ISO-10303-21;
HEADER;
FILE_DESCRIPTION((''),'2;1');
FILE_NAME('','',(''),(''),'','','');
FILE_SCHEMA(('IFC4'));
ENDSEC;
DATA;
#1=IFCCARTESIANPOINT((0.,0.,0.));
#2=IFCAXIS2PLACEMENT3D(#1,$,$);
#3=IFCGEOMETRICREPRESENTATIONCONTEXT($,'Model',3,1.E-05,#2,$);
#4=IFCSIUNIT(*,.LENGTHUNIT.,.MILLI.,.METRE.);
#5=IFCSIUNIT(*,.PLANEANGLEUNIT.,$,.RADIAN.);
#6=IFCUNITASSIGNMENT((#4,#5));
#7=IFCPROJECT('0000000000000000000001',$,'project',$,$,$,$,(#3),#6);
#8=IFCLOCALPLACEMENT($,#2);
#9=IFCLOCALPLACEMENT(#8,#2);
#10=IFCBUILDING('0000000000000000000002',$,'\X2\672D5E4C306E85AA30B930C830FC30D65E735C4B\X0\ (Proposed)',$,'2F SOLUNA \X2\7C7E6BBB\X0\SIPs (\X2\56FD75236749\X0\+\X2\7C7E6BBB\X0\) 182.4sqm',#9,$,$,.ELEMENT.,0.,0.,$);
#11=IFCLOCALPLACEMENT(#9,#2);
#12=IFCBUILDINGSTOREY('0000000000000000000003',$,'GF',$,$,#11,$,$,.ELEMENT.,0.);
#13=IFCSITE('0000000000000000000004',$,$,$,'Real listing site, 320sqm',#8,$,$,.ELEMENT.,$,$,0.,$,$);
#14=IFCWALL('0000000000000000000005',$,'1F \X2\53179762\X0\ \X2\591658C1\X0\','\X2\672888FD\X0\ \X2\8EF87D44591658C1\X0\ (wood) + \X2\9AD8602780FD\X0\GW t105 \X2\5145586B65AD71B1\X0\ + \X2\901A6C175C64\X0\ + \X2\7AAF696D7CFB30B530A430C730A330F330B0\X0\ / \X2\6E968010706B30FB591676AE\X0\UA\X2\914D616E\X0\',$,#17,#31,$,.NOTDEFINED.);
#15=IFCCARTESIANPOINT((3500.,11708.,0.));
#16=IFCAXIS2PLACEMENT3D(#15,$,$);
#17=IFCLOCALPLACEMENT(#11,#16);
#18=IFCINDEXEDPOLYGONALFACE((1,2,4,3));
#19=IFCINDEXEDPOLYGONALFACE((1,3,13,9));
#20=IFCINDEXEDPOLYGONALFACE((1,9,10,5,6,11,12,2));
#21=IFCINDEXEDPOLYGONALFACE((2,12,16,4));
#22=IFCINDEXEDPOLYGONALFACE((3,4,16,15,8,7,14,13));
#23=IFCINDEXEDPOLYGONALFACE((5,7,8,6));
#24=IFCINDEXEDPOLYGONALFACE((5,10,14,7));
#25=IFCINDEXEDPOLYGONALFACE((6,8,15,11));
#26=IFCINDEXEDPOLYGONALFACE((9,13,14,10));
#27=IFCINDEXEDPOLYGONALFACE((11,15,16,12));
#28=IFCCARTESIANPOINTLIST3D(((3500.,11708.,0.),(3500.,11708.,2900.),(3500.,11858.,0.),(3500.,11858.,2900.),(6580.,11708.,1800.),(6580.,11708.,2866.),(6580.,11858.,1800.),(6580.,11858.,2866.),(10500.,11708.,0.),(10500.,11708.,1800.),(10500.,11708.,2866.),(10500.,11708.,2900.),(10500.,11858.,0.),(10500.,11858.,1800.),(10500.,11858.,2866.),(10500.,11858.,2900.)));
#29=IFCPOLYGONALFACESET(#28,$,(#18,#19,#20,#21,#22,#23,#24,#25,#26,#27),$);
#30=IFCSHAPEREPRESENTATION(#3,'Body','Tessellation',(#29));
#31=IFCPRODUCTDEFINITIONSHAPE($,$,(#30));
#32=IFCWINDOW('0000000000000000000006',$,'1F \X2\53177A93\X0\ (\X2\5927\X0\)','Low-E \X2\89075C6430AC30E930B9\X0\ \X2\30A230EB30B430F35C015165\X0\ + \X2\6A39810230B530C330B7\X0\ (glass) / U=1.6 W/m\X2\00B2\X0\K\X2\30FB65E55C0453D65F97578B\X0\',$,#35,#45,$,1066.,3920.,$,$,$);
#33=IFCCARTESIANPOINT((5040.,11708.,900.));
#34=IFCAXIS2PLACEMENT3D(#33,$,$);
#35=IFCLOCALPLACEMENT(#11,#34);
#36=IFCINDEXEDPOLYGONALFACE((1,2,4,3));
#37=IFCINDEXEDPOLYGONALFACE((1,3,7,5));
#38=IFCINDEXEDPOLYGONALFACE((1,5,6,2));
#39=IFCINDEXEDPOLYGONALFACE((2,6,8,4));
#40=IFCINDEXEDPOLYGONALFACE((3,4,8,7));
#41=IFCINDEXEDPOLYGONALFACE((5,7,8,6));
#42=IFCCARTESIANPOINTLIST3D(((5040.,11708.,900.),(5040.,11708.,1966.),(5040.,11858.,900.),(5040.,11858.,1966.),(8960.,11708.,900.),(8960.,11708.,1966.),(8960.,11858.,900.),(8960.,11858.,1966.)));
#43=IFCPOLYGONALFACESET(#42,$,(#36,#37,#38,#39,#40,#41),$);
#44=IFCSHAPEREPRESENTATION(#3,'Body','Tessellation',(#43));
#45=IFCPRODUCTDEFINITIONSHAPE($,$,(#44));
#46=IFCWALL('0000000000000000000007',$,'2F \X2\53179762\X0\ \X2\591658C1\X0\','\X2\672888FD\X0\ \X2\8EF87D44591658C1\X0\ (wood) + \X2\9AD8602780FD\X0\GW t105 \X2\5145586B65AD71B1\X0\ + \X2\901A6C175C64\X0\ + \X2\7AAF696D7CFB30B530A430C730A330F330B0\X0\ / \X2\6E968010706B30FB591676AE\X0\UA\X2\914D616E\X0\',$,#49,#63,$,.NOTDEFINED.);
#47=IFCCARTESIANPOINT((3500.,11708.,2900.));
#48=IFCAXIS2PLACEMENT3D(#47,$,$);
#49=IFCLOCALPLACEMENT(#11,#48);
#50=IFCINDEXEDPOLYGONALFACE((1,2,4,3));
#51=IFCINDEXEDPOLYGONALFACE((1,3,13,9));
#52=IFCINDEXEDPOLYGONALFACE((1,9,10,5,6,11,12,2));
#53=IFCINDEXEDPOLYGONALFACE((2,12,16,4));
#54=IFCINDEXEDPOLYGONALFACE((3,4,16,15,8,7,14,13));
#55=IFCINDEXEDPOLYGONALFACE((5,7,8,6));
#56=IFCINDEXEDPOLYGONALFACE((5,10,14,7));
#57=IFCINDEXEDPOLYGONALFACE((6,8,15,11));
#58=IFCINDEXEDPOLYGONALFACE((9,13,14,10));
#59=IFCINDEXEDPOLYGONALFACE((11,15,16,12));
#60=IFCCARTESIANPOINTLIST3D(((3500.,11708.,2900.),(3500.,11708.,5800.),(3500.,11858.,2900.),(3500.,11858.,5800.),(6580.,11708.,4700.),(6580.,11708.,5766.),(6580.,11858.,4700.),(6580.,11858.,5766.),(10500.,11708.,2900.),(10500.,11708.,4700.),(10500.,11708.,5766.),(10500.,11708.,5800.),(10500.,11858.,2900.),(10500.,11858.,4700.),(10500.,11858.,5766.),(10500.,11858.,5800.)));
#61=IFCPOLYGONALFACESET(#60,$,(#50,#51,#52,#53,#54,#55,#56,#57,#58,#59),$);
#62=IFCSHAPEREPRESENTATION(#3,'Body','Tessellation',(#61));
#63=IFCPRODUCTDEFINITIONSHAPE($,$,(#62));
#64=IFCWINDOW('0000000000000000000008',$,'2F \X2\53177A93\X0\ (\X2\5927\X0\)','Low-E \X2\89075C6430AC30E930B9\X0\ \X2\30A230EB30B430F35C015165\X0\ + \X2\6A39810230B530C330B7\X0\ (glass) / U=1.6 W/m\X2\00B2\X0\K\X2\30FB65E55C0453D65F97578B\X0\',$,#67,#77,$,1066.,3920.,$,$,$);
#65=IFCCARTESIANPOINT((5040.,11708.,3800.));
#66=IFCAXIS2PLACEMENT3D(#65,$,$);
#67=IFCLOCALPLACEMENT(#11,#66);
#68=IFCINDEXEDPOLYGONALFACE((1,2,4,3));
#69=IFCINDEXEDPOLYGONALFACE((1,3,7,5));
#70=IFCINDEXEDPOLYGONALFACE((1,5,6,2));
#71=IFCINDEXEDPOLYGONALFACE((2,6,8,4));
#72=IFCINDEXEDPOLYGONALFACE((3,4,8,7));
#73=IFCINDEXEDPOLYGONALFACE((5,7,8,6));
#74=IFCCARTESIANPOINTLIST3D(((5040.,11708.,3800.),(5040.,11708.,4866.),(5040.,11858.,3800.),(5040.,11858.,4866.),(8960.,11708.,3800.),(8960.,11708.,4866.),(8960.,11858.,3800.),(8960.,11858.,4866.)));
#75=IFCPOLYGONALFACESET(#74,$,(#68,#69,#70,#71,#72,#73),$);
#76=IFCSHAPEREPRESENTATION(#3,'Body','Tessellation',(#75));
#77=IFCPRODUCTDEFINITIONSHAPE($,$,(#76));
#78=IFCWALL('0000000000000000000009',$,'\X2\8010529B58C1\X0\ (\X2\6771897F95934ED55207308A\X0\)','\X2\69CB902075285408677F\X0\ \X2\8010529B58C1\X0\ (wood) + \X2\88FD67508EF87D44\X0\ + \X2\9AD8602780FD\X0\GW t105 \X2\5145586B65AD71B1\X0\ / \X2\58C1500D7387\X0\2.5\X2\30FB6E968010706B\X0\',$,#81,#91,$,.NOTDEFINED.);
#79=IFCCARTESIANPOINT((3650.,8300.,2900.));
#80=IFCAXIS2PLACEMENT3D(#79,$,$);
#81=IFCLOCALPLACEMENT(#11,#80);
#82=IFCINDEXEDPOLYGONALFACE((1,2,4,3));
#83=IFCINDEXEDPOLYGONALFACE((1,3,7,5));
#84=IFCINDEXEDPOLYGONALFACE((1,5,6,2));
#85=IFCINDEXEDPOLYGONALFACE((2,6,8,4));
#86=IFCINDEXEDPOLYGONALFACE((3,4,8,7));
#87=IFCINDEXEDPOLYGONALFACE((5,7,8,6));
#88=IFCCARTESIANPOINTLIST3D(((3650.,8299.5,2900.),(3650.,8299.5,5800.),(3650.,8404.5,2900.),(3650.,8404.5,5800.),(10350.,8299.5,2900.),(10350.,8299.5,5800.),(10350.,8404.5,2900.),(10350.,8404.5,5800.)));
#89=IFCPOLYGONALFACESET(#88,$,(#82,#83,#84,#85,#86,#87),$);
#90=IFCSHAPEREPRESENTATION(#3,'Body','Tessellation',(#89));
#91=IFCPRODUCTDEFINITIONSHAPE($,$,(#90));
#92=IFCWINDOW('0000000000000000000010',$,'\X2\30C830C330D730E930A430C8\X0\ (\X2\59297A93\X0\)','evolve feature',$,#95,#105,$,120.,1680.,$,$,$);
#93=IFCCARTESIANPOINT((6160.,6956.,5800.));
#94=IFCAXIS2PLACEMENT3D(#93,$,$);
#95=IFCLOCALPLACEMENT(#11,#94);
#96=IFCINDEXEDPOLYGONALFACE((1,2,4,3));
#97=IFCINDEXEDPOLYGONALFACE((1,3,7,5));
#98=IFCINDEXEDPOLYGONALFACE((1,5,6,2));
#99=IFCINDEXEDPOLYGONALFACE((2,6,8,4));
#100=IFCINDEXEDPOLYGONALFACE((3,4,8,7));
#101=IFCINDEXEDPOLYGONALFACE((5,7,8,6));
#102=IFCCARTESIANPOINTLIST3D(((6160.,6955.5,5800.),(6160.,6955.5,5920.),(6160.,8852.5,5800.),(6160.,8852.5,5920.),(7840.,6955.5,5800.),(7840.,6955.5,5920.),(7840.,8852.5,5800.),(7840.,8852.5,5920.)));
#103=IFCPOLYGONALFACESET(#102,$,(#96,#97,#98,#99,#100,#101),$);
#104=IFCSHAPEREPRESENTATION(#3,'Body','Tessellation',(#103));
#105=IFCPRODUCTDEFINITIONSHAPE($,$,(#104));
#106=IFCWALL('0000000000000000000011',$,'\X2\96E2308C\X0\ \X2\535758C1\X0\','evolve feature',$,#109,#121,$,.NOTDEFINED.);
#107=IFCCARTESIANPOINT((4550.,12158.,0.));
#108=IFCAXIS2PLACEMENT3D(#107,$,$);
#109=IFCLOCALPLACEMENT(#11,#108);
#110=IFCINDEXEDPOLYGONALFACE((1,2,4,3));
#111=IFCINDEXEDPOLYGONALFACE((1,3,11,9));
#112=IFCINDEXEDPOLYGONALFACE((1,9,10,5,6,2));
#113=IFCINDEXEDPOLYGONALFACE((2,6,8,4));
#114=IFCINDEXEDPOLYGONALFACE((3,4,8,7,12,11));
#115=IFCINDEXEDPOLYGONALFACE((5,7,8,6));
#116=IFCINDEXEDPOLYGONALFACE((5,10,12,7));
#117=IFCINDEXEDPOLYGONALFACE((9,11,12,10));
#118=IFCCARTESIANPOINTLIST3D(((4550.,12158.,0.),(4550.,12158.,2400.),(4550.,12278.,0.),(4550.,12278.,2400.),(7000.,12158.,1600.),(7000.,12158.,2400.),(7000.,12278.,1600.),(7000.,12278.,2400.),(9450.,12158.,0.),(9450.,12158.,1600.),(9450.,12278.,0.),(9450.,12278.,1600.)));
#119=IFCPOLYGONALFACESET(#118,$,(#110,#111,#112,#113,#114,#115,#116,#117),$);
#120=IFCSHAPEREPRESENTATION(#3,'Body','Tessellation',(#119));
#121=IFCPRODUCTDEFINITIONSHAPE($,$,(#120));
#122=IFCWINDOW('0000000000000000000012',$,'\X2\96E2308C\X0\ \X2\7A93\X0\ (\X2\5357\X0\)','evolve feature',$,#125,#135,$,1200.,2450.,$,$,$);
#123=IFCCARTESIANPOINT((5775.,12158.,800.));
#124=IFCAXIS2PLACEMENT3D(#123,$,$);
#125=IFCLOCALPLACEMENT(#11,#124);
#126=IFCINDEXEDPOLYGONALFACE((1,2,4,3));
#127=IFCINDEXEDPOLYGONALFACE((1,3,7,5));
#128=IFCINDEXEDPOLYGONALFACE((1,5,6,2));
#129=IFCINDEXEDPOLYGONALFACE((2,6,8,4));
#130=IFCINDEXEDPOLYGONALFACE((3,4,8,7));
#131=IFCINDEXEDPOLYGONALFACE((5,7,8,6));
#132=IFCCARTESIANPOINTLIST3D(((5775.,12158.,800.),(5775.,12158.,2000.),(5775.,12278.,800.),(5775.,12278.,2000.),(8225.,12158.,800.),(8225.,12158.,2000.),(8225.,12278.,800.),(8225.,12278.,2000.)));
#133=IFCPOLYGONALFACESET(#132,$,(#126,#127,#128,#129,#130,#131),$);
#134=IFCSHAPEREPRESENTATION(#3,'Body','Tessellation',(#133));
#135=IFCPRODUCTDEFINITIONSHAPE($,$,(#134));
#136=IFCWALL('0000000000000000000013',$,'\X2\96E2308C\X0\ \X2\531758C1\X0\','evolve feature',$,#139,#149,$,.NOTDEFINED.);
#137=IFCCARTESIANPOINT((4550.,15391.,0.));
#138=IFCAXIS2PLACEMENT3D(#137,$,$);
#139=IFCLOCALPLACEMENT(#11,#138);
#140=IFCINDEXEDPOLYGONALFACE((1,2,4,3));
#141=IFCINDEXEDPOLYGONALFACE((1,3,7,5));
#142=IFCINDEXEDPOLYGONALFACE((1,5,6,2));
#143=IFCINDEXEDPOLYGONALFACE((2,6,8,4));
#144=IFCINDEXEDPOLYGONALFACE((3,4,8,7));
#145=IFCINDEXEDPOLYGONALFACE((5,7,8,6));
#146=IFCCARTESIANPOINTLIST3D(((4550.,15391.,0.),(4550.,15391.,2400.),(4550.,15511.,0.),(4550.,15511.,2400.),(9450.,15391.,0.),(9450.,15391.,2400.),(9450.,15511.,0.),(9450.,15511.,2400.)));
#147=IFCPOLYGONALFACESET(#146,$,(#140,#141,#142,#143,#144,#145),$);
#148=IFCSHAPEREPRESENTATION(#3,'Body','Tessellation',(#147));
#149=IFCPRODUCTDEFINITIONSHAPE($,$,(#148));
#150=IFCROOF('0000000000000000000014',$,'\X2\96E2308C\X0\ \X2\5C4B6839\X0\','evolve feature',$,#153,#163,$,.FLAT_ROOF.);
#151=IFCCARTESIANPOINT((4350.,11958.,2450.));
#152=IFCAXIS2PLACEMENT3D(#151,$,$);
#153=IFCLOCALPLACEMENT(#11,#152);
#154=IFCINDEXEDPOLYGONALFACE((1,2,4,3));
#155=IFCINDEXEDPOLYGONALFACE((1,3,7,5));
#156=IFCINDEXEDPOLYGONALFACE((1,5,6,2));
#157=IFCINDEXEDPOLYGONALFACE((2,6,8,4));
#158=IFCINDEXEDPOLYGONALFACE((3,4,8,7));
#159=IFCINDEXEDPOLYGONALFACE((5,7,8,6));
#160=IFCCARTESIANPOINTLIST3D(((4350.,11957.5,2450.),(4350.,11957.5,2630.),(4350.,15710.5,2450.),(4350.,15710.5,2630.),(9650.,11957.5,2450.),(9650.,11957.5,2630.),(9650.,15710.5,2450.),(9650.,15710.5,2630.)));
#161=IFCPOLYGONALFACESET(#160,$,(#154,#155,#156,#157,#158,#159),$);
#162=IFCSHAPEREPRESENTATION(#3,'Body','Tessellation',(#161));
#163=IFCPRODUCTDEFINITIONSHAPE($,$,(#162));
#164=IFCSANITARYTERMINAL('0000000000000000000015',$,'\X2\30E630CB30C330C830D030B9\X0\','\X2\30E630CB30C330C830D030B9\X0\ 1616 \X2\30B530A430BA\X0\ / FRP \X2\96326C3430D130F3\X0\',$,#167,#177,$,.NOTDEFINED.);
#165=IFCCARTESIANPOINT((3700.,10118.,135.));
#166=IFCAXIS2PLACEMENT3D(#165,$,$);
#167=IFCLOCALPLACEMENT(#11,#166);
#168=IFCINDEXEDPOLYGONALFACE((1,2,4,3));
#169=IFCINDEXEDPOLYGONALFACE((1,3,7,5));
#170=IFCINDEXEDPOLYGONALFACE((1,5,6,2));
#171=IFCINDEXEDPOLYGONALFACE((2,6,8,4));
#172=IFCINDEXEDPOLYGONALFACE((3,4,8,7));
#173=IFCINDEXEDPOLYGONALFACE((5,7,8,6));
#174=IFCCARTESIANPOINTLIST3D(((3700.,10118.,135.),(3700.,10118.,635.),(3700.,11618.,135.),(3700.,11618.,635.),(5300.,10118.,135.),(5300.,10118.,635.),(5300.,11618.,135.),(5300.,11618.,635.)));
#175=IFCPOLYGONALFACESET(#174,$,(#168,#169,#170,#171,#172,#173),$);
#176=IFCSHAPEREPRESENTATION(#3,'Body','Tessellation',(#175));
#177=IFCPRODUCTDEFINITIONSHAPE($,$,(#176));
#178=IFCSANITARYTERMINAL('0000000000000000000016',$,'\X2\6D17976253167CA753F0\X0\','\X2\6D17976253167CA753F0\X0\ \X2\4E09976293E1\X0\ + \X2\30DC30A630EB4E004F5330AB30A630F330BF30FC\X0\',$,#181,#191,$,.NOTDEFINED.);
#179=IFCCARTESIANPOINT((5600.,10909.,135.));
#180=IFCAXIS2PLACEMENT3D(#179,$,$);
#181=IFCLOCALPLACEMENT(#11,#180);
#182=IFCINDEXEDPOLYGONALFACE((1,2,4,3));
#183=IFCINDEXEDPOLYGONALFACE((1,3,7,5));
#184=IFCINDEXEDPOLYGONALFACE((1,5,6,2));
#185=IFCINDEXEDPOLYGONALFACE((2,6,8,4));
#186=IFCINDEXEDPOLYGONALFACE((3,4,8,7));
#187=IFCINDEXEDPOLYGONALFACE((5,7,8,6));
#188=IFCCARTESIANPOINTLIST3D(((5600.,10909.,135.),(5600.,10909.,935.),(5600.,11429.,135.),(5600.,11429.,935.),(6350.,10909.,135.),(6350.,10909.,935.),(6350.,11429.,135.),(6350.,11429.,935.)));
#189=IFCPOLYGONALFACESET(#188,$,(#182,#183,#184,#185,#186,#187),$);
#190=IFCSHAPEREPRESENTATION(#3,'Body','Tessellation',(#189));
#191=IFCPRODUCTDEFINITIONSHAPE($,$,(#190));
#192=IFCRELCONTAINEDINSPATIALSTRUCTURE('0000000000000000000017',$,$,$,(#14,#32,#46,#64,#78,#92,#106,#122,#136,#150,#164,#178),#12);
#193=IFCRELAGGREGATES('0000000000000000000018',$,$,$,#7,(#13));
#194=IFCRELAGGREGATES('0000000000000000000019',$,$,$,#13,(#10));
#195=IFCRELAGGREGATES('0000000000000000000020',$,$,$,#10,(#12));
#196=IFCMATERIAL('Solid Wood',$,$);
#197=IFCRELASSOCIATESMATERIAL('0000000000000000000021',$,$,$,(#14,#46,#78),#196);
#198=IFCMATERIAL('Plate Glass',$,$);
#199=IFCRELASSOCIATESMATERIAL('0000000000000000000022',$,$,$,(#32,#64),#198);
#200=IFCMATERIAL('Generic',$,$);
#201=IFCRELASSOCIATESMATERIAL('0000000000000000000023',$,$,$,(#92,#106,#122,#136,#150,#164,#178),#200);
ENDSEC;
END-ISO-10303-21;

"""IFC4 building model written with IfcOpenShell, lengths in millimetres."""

from ifc_helpers import new_model, si_unit, frame, frame_2d, origin, place, context, project, spatial, rectangle, extrude, material, element, fill, save


model = new_model("IFC4")

# Units and contexts
model_context = context("Model", 3, precision=1e-05, world=origin())
ifc_project = project(units=[si_unit("LENGTHUNIT", "METRE", prefix="MILLI"), si_unit("PLANEANGLEUNIT", "RADIAN")], contexts=[model_context])

# Site, building, storey
site_placement = place(None, origin())
site = spatial("IfcSite", under=ifc_project, at=site_placement, ObjectType="Real listing site, 320sqm", CompositionType="ELEMENT", RefElevation=0.0)
building_placement = place(site_placement, origin())
building = spatial("IfcBuilding", under=site, at=building_placement, Name="札幌の薪ストーブ平屋 (Proposed)", ObjectType="2F SOLUNA 籾殻SIPs (国産杉+籾殻) 182.4sqm", CompositionType="ELEMENT", ElevationOfRefHeight=0.0, ElevationOfTerrain=0.0)
storey_placement = place(building_placement, origin())
storey = spatial("IfcBuildingStorey", under=building, at=storey_placement, Name="GF", CompositionType="ELEMENT", Elevation=0.0)

# Shared definitions
ifc_material_1 = material(Name="Generic")

# Wall, opening, window
ifc_material_2 = material(Name="Solid Wood")
wall_1_placement = place(storey_placement, frame((3500.0, 11708.0, 0.0)))
wall_1 = element("IfcWall", 1, at=wall_1_placement, inside=storey, material=ifc_material_2, Name="1F 北面 外壁", Description="木製 軸組外壁 (wood) + 高性能GW t105 充填断熱 + 通気層 + 窯業系サイディング / 準耐火・外皮UA配慮", PredefinedType="NOTDEFINED", context=model_context, shape_type="SweptSolid", body=[
    extrude(rectangle(XDim=7000.0, YDim=150.0, at=frame_2d((3500.0, 75.0))), frame((3500.0, 11708.0, 0.0)), (0.0, 0.0, 1.0), 2900.0),
])
opening_1_placement = place(storey_placement, frame((5040.0, 11708.0, 900.0)))
opening_1 = element("IfcOpeningElement", 2, at=opening_1_placement, cuts=wall_1, PredefinedType="NOTDEFINED", context=model_context, shape_type="SweptSolid", body=[
    extrude(rectangle(XDim=3920.0, YDim=150.0, at=frame_2d((1960.0, 75.0))), frame((5040.0, 11708.0, 900.0)), (0.0, 0.0, 1.0), 1066.0),
])
ifc_material_3 = material(Name="Plate Glass")
window_1_placement = place(storey_placement, frame((5040.0, 11708.0, 900.0)))
window_1 = element("IfcWindow", 3, at=window_1_placement, inside=storey, material=ifc_material_3, Name="1F 北窓 (大)", Description="Low-E 複層ガラス アルゴン封入 + 樹脂サッシ (glass) / U=1.6 W/m²K・日射取得型", OverallHeight=1066.0, OverallWidth=3920.0, context=model_context, shape_type="SweptSolid", body=[
    extrude(rectangle(XDim=3920.0, YDim=150.0, at=frame_2d((1960.0, 75.0))), frame((5040.0, 11708.0, 900.0)), (0.0, 0.0, 1.0), 1066.0),
])
fill(opening_1, window_1)

# Wall, opening, window
wall_2_placement = place(storey_placement, frame((3500.0, 11708.0, 2900.0)))
wall_2 = element("IfcWall", 4, at=wall_2_placement, inside=storey, material=ifc_material_2, Name="2F 北面 外壁", Description="木製 軸組外壁 (wood) + 高性能GW t105 充填断熱 + 通気層 + 窯業系サイディング / 準耐火・外皮UA配慮", PredefinedType="NOTDEFINED", context=model_context, shape_type="SweptSolid", body=[
    extrude(rectangle(XDim=7000.0, YDim=150.0, at=frame_2d((3500.0, 75.0))), frame((3500.0, 11708.0, 2900.0)), (0.0, 0.0, 1.0), 2900.0),
])
opening_2_placement = place(storey_placement, frame((5040.0, 11708.0, 3800.0)))
opening_2 = element("IfcOpeningElement", 5, at=opening_2_placement, cuts=wall_2, PredefinedType="NOTDEFINED", context=model_context, shape_type="SweptSolid", body=[
    extrude(rectangle(XDim=3920.0, YDim=150.0, at=frame_2d((1960.0, 75.0))), frame((5040.0, 11708.0, 3800.0)), (0.0, 0.0, 1.0), 1066.0),
])
window_2_placement = place(storey_placement, frame((5040.0, 11708.0, 3800.0)))
window_2 = element("IfcWindow", 6, at=window_2_placement, inside=storey, material=ifc_material_3, Name="2F 北窓 (大)", Description="Low-E 複層ガラス アルゴン封入 + 樹脂サッシ (glass) / U=1.6 W/m²K・日射取得型", OverallHeight=1066.0, OverallWidth=3920.0, context=model_context, shape_type="SweptSolid", body=[
    extrude(rectangle(XDim=3920.0, YDim=150.0, at=frame_2d((1960.0, 75.0))), frame((5040.0, 11708.0, 3800.0)), (0.0, 0.0, 1.0), 1066.0),
])
fill(opening_2, window_2)

# Wall
wall_3_placement = place(storey_placement, frame((3650.0, 8300.0, 2900.0)))
element("IfcWall", 7, at=wall_3_placement, inside=storey, material=ifc_material_2, Name="耐力壁 (東西間仕切り)", Description="構造用合板 耐力壁 (wood) + 製材軸組 + 高性能GW t105 充填断熱 / 壁倍率2.5・準耐火", PredefinedType="NOTDEFINED", context=model_context, shape_type="SweptSolid", body=[
    extrude(rectangle(XDim=6700.0, YDim=105.0, at=frame_2d((3350.0, 52.0))), frame((3650.0, 8300.0, 2900.0)), (0.0, 0.0, 1.0), 2900.0),
])

# Window
window_3_placement = place(storey_placement, frame((6160.0, 6956.0, 5800.0)))
element("IfcWindow", 8, at=window_3_placement, inside=storey, material=ifc_material_1, Name="トップライト (天窓)", Description="evolve feature", OverallHeight=120.0, OverallWidth=1680.0, context=model_context, shape_type="SweptSolid", body=[
    extrude(rectangle(XDim=1680.0, YDim=1897.0, at=frame_2d((840.0, 948.0))), frame((6160.0, 6956.0, 5800.0)), (0.0, 0.0, 1.0), 120.0),
])

# Wall, opening, window
wall_4_placement = place(storey_placement, frame((4550.0, 12158.0, 0.0)))
wall_4 = element("IfcWall", 9, at=wall_4_placement, inside=storey, material=ifc_material_1, Name="離れ 南壁", Description="evolve feature", PredefinedType="NOTDEFINED", context=model_context, shape_type="SweptSolid", body=[
    extrude(rectangle(XDim=4900.0, YDim=120.0, at=frame_2d((2450.0, 60.0))), frame((4550.0, 12158.0, 0.0)), (0.0, 0.0, 1.0), 2400.0),
])
opening_3_placement = place(storey_placement, frame((5775.0, 12158.0, 800.0)))
opening_3 = element("IfcOpeningElement", 10, at=opening_3_placement, cuts=wall_4, PredefinedType="NOTDEFINED", context=model_context, shape_type="SweptSolid", body=[
    extrude(rectangle(XDim=2450.0, YDim=120.0, at=frame_2d((1225.0, 60.0))), frame((5775.0, 12158.0, 800.0)), (0.0, 0.0, 1.0), 1200.0),
])
window_4_placement = place(storey_placement, frame((5775.0, 12158.0, 800.0)))
window_4 = element("IfcWindow", 11, at=window_4_placement, inside=storey, material=ifc_material_1, Name="離れ 窓 (南)", Description="evolve feature", OverallHeight=1200.0, OverallWidth=2450.0, context=model_context, shape_type="SweptSolid", body=[
    extrude(rectangle(XDim=2450.0, YDim=120.0, at=frame_2d((1225.0, 60.0))), frame((5775.0, 12158.0, 800.0)), (0.0, 0.0, 1.0), 1200.0),
])
fill(opening_3, window_4)

# Wall
wall_5_placement = place(storey_placement, frame((4550.0, 15391.0, 0.0)))
element("IfcWall", 12, at=wall_5_placement, inside=storey, material=ifc_material_1, Name="離れ 北壁", Description="evolve feature", PredefinedType="NOTDEFINED", context=model_context, shape_type="SweptSolid", body=[
    extrude(rectangle(XDim=4900.0, YDim=120.0, at=frame_2d((2450.0, 60.0))), frame((4550.0, 15391.0, 0.0)), (0.0, 0.0, 1.0), 2400.0),
])

# Roof
roof_placement = place(storey_placement, frame((4350.0, 11958.0, 2450.0)))
element("IfcRoof", 13, at=roof_placement, inside=storey, material=ifc_material_1, Name="離れ 屋根", Description="evolve feature", PredefinedType="FLAT_ROOF", context=model_context, shape_type="SweptSolid", body=[
    extrude(rectangle(XDim=5300.0, YDim=3753.0, at=frame_2d((2650.0, 1876.0))), frame((4350.0, 11958.0, 2450.0)), (0.0, 0.0, 1.0), 180.0),
])

# Sanitary terminals
sanitary_terminal_1_placement = place(storey_placement, frame((3700.0, 10118.0, 135.0)))
element("IfcSanitaryTerminal", 14, at=sanitary_terminal_1_placement, inside=storey, material=ifc_material_1, Name="ユニットバス", Description="ユニットバス 1616 サイズ / FRP 防水パン", PredefinedType="NOTDEFINED", context=model_context, shape_type="SweptSolid", body=[
    extrude(rectangle(XDim=1600.0, YDim=1500.0, at=frame_2d((800.0, 750.0))), frame((3700.0, 10118.0, 135.0)), (0.0, 0.0, 1.0), 500.0),
])
sanitary_terminal_2_placement = place(storey_placement, frame((5600.0, 10909.0, 135.0)))
element("IfcSanitaryTerminal", 15, at=sanitary_terminal_2_placement, inside=storey, material=ifc_material_1, Name="洗面化粧台", Description="洗面化粧台 三面鏡 + ボウル一体カウンター", PredefinedType="NOTDEFINED", context=model_context, shape_type="SweptSolid", body=[
    extrude(rectangle(XDim=750.0, YDim=520.0, at=frame_2d((375.0, 260.0))), frame((5600.0, 10909.0, 135.0)), (0.0, 0.0, 1.0), 800.0),
])

save(model, "model.ifc")
